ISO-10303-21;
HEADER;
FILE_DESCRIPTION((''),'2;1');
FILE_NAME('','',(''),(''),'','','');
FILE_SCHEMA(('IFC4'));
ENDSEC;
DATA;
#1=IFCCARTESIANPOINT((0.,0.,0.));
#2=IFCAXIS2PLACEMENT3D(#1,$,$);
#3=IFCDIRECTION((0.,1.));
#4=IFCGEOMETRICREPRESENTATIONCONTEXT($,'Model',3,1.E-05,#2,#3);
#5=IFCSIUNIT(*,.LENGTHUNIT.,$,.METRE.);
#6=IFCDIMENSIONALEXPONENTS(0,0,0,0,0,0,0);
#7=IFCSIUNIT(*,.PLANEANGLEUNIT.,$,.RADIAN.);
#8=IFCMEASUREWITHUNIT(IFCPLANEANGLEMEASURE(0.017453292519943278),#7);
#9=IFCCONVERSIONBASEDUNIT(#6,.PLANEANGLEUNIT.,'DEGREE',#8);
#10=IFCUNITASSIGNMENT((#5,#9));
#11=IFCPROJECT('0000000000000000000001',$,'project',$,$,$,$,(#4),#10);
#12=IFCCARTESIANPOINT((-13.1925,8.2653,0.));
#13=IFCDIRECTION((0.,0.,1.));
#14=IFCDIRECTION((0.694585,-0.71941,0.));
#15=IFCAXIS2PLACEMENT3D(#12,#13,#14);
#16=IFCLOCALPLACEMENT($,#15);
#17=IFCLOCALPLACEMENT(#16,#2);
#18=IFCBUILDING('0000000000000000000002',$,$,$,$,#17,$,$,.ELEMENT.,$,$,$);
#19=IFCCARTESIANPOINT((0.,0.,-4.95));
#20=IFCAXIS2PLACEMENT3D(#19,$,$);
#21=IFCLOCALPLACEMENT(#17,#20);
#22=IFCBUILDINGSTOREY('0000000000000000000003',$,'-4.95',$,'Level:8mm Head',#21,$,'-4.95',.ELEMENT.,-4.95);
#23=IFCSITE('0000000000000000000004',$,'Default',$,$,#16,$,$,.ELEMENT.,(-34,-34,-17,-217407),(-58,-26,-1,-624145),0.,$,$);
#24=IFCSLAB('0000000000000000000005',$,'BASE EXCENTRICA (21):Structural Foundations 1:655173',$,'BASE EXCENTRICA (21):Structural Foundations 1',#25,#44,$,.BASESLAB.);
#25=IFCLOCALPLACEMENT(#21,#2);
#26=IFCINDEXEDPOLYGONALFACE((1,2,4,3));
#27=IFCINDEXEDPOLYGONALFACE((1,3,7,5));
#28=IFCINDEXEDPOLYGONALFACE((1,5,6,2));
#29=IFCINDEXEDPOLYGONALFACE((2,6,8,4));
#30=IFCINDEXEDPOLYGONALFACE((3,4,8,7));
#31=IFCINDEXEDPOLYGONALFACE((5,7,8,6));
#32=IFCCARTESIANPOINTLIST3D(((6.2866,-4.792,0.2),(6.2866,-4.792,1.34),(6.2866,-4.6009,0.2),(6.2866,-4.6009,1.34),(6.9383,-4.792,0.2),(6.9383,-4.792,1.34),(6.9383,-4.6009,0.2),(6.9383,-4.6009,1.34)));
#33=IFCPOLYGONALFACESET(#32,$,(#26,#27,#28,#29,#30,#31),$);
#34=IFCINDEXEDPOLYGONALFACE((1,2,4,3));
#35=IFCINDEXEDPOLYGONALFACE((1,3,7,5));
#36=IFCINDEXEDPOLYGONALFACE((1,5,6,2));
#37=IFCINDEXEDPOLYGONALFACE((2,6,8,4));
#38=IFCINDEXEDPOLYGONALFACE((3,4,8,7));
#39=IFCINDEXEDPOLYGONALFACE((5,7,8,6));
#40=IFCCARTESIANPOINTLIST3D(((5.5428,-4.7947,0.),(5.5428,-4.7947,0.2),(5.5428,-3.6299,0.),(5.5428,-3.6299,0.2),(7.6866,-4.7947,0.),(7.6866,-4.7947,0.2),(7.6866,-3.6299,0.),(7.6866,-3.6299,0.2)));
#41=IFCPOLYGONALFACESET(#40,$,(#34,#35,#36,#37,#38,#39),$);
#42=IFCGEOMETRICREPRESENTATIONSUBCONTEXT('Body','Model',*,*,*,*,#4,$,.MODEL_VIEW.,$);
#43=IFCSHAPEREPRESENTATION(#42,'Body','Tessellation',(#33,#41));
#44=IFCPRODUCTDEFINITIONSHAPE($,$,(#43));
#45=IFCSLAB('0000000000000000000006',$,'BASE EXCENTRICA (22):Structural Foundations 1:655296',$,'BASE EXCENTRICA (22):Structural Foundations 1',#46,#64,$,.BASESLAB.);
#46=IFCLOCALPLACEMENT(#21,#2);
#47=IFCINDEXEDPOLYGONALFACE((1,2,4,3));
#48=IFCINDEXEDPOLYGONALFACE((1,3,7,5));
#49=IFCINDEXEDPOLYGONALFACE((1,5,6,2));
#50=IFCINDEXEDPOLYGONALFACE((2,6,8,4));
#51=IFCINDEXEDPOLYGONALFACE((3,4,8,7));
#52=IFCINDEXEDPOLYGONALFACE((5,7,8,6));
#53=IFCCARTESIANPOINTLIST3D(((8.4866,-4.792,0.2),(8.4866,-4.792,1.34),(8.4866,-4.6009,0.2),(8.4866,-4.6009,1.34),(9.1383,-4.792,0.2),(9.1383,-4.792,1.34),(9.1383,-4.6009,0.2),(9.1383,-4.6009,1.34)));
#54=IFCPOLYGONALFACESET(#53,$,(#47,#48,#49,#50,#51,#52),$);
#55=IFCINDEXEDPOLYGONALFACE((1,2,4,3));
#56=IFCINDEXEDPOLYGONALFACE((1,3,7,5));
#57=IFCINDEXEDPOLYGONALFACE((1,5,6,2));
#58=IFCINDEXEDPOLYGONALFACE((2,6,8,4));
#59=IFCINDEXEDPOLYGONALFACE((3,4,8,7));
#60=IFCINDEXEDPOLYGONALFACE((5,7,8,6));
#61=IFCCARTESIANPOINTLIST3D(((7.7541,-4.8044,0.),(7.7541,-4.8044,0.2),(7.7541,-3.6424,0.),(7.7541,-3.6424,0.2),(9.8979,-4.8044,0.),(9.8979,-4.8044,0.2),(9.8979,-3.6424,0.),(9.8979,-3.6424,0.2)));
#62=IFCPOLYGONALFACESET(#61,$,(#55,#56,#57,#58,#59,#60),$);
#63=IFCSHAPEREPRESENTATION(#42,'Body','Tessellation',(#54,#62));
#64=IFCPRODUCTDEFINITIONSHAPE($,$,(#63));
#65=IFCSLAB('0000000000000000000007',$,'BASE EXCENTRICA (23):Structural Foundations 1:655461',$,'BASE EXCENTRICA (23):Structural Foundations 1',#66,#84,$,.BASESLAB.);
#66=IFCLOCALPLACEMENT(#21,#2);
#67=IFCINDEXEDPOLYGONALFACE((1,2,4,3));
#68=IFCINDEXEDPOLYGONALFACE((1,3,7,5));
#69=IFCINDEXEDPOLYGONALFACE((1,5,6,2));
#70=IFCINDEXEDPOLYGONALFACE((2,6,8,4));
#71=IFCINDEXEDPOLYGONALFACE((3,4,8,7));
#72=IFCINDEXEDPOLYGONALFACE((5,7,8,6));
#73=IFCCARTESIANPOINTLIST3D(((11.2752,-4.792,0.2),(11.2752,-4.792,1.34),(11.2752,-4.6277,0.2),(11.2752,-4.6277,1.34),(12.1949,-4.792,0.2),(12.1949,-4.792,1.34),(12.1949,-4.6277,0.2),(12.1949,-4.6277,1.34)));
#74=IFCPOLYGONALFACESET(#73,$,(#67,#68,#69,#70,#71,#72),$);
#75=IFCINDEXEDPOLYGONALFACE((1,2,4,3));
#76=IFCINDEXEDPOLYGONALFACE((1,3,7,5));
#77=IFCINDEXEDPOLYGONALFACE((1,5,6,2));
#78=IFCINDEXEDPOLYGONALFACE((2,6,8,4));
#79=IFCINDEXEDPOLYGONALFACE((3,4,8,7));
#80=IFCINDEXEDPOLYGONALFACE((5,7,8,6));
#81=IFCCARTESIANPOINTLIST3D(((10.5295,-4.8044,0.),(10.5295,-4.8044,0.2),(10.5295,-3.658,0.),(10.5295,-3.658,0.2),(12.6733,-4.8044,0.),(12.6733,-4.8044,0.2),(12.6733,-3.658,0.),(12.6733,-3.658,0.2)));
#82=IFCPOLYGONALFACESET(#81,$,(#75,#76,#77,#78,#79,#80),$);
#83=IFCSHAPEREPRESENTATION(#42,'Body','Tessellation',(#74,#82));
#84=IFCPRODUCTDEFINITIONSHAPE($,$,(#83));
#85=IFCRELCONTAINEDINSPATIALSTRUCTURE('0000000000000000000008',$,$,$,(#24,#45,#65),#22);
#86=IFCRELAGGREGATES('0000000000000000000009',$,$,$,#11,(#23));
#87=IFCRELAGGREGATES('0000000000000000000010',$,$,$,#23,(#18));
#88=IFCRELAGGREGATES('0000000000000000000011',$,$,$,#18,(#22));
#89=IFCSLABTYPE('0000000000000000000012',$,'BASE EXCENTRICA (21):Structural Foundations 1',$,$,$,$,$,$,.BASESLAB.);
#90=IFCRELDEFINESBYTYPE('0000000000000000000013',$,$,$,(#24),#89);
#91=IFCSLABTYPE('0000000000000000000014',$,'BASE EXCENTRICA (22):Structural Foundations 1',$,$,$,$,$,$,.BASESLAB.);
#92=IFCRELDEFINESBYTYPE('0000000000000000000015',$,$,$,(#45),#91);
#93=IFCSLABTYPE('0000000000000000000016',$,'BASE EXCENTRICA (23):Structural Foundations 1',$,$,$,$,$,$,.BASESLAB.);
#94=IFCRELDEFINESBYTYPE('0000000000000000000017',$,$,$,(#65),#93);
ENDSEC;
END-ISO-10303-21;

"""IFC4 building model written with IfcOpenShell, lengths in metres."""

from ifc_helpers import new_model, entity, si_unit, converted_unit, direction, frame, origin, place, context, subcontext, project, spatial, indexed_curve, outline, extrude, type_object, element, save


model = new_model("IFC4")

# Units and contexts
model_context = context("Model", 3, precision=1e-05, world=origin(), true_north=direction((0.0, 1.0)))
body_context = subcontext(model_context, "Body", "Model", "MODEL_VIEW")
ifc_project = project(units=[si_unit("LENGTHUNIT", "METRE"), converted_unit("PLANEANGLEUNIT", "DEGREE", entity("IfcPlaneAngleMeasure", 0.017453292519943278), si_unit("PLANEANGLEUNIT", "RADIAN"), dimensions=[0, 0, 0, 0, 0, 0, 0])], contexts=[model_context])

# Site, building, storey
site_placement = place(None, frame((-13.1925, 8.2653, 0.0), z_axis=(0.0, 0.0, 1.0), x_axis=(0.694585, -0.71941, 0.0)))
site = spatial("IfcSite", under=ifc_project, at=site_placement, Name="Default", CompositionType="ELEMENT", RefLatitude=(-34, -34, -17, -217407), RefLongitude=(-58, -26, -1, -624145), RefElevation=0.0)
building_placement = place(site_placement, origin())
building = spatial("IfcBuilding", under=site, at=building_placement, CompositionType="ELEMENT")
storey_placement = place(building_placement, frame((0.0, 0.0, -4.95)))
storey = spatial("IfcBuildingStorey", under=building, at=storey_placement, Name="-4.95", ObjectType="Level:8mm Head", LongName="-4.95", CompositionType="ELEMENT", Elevation=-4.95)

# Slabs
slab_type_1 = type_object("IfcSlabType", Name="BASE EXCENTRICA (21):Structural Foundations 1", PredefinedType="BASESLAB")
slab_1_placement = place(storey_placement, origin())
element("IfcSlab", 1, at=slab_1_placement, inside=storey, type_object=slab_type_1, Name="BASE EXCENTRICA (21):Structural Foundations 1:655173", ObjectType="BASE EXCENTRICA (21):Structural Foundations 1", PredefinedType="BASESLAB", context=body_context, shape_type="SweptSolid", body=[
    extrude(outline(indexed_curve([(-0.0955, -0.3258), (0.0955, -0.3258), (0.0955, 0.3258), (-0.0955, 0.3258), (-0.0955, -0.3258)], self_intersect=False)), frame((6.6125, -4.6965, 0.2), z_axis=(0.0, 0.0, 1.0), x_axis=(0.0, 1.0, 0.0)), (0.0, 0.0, 1.0), 1.14),
    extrude(outline(indexed_curve([(-1.0719, -0.5824), (1.0719, -0.5824), (1.0719, 0.5824), (-1.0719, 0.5824), (-1.0719, -0.5824)], self_intersect=False)), frame((6.6147, -4.2123, 0.0)), (0.0, 0.0, 1.0), 0.2),
])
slab_type_2 = type_object("IfcSlabType", Name="BASE EXCENTRICA (22):Structural Foundations 1", PredefinedType="BASESLAB")
slab_2_placement = place(storey_placement, origin())
element("IfcSlab", 2, at=slab_2_placement, inside=storey, type_object=slab_type_2, Name="BASE EXCENTRICA (22):Structural Foundations 1:655296", ObjectType="BASE EXCENTRICA (22):Structural Foundations 1", PredefinedType="BASESLAB", context=body_context, shape_type="SweptSolid", body=[
    extrude(outline(indexed_curve([(-0.0955, -0.3258), (0.0955, -0.3258), (0.0955, 0.3258), (-0.0955, 0.3258), (-0.0955, -0.3258)], self_intersect=False)), frame((8.8125, -4.6965, 0.2), z_axis=(0.0, 0.0, 1.0), x_axis=(0.0, 1.0, 0.0)), (0.0, 0.0, 1.0), 1.14),
    extrude(outline(indexed_curve([(-1.0719, -0.581), (1.0719, -0.581), (1.0719, 0.581), (-1.0719, 0.581), (-1.0719, -0.581)], self_intersect=False)), frame((8.826, -4.2234, 0.0)), (0.0, 0.0, 1.0), 0.2),
])
slab_type_3 = type_object("IfcSlabType", Name="BASE EXCENTRICA (23):Structural Foundations 1", PredefinedType="BASESLAB")
slab_3_placement = place(storey_placement, origin())
element("IfcSlab", 3, at=slab_3_placement, inside=storey, type_object=slab_type_3, Name="BASE EXCENTRICA (23):Structural Foundations 1:655461", ObjectType="BASE EXCENTRICA (23):Structural Foundations 1", PredefinedType="BASESLAB", context=body_context, shape_type="SweptSolid", body=[
    extrude(outline(indexed_curve([(-0.0821, -0.4599), (0.0821, -0.4599), (0.0821, 0.4599), (-0.0821, 0.4599), (-0.0821, -0.4599)], self_intersect=False)), frame((11.7351, -4.7099, 0.2), z_axis=(0.0, 0.0, 1.0), x_axis=(0.0, 1.0, 0.0)), (0.0, 0.0, 1.0), 1.14),
    extrude(outline(indexed_curve([(-1.0719, -0.5732), (1.0719, -0.5732), (1.0719, 0.5732), (-1.0719, 0.5732), (-1.0719, -0.5732)], self_intersect=False)), frame((11.6014, -4.2312, 0.0)), (0.0, 0.0, 1.0), 0.2),
])

save(model, "model.ifc")
